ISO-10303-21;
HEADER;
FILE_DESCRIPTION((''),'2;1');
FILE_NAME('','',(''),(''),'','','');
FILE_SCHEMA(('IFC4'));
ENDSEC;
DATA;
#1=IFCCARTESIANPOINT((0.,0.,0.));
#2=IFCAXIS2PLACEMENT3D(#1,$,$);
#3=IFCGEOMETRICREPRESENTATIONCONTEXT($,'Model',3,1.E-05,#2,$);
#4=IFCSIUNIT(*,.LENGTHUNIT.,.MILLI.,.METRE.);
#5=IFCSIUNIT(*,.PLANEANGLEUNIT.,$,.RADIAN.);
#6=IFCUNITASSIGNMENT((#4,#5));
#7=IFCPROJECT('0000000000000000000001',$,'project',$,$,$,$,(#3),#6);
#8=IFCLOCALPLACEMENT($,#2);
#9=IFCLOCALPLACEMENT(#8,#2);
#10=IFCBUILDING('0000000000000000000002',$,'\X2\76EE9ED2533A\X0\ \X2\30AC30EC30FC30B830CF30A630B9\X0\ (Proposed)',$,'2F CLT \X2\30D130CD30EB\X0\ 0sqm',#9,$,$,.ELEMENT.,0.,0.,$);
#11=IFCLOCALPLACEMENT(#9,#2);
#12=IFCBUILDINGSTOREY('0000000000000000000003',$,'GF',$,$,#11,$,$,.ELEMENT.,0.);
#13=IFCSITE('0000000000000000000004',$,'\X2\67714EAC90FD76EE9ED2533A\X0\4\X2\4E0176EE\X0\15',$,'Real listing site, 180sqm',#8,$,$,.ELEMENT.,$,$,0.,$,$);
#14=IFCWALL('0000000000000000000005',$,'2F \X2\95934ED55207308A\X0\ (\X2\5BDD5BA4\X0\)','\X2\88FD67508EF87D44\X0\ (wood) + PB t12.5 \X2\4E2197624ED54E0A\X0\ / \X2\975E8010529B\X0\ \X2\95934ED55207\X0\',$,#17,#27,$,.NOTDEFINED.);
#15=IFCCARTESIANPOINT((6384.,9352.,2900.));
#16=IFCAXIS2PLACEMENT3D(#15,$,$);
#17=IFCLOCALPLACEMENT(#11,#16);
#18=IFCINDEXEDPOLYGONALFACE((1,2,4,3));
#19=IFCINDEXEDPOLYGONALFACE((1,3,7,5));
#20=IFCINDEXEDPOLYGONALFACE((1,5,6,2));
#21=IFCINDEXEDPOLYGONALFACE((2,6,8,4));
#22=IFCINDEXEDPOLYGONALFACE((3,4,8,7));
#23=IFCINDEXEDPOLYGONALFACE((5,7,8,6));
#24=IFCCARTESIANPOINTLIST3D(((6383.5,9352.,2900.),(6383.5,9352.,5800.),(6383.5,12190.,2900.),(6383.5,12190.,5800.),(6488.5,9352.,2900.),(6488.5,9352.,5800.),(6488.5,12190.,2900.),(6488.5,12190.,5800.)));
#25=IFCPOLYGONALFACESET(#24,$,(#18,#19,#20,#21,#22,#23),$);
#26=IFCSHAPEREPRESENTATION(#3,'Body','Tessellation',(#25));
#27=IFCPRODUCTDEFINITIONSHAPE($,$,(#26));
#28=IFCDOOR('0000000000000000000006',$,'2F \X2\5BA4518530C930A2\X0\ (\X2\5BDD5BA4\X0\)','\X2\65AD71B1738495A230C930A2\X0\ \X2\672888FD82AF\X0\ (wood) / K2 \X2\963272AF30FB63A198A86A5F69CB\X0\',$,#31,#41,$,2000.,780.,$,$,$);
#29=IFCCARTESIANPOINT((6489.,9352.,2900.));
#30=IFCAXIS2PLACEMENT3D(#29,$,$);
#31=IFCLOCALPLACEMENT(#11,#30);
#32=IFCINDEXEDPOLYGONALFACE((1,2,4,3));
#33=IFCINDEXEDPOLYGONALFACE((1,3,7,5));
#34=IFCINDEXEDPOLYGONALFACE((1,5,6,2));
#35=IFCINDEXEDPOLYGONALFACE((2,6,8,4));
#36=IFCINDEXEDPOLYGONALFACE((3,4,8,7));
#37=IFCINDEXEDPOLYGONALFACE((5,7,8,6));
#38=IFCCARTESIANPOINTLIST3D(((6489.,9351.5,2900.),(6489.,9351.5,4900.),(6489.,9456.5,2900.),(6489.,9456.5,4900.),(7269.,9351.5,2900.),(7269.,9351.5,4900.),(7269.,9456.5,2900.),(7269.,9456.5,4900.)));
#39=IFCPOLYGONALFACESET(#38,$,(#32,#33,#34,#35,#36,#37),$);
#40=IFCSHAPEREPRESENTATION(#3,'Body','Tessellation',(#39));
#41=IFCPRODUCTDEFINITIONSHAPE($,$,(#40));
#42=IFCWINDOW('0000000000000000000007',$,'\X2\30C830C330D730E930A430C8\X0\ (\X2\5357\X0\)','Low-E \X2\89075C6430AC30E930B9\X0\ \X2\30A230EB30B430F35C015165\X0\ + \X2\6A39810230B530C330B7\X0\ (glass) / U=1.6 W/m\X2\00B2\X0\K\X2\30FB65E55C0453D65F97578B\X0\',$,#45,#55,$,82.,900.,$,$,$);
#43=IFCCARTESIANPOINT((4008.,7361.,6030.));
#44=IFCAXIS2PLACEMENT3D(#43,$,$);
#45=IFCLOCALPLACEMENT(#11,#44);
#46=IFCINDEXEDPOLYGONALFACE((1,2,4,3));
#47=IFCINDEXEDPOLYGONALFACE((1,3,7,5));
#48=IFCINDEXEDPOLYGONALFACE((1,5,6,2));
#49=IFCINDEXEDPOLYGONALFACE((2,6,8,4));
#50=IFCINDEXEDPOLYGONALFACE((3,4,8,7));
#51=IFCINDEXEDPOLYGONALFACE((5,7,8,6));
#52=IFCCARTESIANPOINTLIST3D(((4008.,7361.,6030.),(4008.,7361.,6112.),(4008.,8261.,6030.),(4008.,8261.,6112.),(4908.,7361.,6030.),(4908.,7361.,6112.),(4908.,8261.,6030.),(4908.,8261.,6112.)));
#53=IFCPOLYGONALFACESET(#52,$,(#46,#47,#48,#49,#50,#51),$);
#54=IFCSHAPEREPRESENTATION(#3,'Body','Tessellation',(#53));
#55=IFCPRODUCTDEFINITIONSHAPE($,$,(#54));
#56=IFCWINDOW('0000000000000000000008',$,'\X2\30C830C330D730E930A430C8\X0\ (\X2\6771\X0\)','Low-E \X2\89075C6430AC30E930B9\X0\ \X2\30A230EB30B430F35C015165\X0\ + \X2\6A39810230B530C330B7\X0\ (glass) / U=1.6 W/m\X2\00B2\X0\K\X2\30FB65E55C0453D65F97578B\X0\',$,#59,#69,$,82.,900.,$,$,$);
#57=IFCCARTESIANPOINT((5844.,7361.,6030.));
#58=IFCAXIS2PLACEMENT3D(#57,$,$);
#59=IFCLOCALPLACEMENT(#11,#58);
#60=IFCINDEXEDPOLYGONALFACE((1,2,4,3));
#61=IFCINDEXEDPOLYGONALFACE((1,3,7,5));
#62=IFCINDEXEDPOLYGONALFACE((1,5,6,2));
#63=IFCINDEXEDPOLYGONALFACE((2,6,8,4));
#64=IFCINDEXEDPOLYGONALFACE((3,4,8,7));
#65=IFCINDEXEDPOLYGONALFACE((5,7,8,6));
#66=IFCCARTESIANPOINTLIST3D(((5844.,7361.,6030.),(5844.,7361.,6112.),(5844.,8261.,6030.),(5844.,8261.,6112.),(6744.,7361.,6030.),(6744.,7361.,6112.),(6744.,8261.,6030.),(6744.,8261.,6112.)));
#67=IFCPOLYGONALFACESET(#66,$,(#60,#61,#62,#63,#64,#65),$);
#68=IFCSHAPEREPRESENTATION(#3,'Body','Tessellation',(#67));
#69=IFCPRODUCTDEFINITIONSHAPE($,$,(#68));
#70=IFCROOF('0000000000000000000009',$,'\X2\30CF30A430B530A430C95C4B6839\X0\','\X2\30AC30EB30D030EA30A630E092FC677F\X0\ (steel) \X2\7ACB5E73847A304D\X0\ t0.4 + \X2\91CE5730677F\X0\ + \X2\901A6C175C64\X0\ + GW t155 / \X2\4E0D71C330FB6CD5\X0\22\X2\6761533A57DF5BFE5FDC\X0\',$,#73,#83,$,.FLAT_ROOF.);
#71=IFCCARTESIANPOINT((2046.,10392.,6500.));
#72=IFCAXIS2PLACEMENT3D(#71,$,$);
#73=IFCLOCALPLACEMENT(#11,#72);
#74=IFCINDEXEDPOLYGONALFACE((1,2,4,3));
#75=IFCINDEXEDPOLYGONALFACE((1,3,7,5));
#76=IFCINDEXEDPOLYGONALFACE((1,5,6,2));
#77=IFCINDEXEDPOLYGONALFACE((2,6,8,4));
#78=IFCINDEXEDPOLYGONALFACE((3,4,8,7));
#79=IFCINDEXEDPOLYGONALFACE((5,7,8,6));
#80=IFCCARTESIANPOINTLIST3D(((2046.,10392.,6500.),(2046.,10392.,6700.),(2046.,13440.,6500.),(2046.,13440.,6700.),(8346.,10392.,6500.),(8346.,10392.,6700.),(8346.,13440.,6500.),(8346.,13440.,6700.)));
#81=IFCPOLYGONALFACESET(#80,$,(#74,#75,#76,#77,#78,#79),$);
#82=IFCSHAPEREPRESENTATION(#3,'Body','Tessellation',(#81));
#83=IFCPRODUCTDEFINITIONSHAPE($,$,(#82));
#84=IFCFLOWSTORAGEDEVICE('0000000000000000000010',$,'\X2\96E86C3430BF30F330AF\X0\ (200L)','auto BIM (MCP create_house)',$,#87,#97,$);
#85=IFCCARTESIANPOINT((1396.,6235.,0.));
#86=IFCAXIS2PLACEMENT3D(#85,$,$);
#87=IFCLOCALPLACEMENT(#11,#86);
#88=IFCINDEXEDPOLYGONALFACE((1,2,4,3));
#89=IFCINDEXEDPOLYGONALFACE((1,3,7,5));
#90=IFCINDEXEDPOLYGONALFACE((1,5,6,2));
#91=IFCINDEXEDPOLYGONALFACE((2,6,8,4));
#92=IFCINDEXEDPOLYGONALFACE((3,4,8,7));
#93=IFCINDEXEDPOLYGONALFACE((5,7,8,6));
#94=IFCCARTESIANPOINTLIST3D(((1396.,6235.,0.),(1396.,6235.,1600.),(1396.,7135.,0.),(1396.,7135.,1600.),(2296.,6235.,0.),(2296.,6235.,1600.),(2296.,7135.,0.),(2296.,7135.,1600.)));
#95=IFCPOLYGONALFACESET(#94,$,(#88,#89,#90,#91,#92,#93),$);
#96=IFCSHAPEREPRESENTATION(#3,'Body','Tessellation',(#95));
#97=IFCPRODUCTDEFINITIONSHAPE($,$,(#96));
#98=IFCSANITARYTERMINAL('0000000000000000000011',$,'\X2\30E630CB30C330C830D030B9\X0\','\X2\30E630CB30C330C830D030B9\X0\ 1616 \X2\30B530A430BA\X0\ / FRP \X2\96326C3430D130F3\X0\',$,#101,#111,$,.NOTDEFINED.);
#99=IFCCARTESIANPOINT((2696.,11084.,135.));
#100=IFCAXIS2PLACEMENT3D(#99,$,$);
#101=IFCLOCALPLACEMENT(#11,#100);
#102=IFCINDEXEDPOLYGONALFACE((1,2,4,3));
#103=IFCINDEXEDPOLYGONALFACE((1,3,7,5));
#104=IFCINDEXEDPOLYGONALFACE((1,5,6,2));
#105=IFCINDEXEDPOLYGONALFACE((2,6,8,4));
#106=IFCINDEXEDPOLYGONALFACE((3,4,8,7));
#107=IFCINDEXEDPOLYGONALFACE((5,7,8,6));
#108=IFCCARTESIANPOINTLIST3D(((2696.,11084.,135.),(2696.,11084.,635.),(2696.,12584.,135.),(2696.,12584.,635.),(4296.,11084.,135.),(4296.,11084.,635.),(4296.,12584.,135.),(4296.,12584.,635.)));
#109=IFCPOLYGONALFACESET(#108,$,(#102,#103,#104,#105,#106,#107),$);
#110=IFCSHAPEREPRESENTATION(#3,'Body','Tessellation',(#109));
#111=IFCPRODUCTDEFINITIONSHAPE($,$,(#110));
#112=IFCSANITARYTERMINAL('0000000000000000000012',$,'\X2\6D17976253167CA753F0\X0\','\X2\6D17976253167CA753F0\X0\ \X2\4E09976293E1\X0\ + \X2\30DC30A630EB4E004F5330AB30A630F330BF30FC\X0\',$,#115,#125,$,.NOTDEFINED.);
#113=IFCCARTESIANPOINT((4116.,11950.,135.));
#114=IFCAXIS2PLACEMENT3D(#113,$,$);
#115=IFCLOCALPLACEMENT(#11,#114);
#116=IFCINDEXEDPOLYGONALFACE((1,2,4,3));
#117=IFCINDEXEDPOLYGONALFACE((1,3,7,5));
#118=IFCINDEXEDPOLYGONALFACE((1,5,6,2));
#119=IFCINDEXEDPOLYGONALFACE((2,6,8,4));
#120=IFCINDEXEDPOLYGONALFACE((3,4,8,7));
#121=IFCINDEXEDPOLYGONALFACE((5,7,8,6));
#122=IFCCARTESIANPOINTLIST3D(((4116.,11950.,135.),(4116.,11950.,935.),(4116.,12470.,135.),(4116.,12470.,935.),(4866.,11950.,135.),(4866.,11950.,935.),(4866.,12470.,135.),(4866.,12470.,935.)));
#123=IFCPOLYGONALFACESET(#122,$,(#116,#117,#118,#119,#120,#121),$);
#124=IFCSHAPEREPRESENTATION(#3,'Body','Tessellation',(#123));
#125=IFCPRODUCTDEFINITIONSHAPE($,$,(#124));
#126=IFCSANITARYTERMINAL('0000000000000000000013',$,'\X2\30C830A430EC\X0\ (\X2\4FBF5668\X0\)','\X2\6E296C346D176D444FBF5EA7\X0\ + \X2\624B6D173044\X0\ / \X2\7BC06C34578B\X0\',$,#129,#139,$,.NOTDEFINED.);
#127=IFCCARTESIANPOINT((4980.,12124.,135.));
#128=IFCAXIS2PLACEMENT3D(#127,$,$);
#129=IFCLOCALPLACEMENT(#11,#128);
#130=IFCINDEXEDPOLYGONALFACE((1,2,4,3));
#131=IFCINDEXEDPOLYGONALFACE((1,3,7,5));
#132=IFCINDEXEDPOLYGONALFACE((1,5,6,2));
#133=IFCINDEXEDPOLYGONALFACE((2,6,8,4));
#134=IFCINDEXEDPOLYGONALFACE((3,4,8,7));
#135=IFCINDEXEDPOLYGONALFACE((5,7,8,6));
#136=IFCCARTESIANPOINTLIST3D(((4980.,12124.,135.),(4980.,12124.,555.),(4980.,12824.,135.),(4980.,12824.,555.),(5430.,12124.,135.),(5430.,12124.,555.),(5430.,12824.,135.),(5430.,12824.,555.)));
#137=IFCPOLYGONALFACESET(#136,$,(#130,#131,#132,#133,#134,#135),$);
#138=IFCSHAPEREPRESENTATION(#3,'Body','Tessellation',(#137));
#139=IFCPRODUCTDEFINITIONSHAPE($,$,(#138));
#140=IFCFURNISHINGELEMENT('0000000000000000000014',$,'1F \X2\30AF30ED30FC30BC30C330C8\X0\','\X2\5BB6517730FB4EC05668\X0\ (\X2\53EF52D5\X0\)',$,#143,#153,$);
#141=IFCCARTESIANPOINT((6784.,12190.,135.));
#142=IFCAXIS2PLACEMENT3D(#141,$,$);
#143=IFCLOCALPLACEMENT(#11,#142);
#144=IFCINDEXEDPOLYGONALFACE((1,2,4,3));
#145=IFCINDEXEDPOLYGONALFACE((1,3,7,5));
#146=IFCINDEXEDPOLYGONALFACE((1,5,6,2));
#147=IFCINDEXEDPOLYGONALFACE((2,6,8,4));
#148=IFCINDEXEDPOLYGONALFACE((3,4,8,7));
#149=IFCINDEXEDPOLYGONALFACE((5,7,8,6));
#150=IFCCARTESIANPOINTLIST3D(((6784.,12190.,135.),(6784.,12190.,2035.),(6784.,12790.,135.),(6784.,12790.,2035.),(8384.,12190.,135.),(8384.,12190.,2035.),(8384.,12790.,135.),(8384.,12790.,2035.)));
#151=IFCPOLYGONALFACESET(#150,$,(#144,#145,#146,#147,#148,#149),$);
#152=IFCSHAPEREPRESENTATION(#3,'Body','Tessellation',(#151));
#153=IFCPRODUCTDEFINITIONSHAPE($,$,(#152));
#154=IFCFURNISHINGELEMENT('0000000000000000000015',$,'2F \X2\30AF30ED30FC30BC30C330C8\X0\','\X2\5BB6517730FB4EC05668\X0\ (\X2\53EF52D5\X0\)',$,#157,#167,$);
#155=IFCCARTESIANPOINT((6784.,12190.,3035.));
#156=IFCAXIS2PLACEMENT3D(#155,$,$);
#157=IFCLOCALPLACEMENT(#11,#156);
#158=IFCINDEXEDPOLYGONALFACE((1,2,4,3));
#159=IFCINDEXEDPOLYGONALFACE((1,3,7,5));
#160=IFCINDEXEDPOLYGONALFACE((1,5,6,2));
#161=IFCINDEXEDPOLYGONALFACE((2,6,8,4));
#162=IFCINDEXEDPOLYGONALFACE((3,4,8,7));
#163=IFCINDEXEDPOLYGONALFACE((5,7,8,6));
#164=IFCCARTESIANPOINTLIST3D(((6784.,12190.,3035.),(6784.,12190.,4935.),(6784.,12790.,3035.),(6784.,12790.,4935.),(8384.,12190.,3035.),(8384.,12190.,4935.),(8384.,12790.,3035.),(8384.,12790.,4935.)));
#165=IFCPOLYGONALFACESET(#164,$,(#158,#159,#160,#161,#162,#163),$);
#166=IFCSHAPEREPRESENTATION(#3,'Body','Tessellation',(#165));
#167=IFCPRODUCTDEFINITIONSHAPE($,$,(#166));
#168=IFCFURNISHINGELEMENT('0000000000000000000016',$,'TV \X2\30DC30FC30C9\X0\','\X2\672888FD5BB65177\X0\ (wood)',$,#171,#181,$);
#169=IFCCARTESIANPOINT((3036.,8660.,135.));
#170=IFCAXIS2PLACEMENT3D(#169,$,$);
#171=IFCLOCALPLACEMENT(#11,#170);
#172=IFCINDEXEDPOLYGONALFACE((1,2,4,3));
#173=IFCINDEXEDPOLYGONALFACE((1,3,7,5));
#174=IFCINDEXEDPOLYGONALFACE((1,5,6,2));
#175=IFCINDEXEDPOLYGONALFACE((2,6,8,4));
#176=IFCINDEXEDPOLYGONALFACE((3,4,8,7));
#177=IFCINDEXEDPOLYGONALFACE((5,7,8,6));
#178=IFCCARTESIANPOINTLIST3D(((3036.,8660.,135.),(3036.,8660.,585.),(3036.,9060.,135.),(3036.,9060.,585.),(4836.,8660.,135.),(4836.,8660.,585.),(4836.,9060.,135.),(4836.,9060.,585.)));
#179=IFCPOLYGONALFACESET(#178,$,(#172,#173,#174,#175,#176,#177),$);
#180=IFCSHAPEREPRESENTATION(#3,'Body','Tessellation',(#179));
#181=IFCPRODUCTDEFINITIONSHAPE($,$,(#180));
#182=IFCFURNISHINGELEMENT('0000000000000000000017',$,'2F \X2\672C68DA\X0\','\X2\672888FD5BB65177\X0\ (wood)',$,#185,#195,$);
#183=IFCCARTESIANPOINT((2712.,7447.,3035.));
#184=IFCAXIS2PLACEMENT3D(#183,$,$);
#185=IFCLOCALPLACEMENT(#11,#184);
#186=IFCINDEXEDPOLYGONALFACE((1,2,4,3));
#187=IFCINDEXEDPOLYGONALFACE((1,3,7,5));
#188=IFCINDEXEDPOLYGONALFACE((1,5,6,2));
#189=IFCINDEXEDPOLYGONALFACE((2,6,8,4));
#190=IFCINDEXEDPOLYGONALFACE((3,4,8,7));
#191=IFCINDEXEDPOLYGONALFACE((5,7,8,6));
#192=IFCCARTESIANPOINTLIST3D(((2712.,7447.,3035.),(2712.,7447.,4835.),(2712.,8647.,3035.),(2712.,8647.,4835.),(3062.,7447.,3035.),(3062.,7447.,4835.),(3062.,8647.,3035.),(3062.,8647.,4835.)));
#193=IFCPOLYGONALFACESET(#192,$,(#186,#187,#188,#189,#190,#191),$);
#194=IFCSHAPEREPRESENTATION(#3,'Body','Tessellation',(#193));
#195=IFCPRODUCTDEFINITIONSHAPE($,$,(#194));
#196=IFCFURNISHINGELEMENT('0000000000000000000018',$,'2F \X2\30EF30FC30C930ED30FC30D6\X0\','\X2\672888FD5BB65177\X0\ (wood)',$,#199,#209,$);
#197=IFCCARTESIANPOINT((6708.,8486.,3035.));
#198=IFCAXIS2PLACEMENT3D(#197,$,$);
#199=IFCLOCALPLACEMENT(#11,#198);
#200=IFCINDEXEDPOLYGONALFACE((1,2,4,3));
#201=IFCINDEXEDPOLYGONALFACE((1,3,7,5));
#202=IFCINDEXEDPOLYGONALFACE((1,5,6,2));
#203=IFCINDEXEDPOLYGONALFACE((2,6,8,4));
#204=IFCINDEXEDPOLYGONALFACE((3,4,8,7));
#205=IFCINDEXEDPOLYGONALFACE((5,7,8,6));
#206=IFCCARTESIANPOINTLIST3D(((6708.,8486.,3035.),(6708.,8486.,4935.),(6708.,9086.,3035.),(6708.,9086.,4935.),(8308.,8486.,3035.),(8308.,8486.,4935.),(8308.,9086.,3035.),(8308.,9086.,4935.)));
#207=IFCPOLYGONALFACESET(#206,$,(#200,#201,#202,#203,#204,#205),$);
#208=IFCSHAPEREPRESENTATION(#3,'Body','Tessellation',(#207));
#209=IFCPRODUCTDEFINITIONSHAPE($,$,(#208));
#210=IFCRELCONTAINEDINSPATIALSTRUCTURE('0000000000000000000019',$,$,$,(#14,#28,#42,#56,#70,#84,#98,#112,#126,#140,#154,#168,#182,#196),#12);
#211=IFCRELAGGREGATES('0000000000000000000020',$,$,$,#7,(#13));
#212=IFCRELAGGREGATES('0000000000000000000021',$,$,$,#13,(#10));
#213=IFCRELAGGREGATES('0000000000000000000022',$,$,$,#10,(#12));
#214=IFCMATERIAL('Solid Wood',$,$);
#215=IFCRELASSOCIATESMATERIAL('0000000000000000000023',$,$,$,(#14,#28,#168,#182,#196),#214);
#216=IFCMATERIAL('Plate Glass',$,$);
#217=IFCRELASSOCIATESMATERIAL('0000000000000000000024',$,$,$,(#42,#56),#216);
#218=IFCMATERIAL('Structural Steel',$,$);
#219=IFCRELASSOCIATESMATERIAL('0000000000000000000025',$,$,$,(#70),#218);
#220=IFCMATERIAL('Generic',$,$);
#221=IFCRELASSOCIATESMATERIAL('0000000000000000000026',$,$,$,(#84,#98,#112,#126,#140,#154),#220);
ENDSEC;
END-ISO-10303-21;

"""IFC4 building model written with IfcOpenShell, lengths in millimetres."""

from ifc_helpers import new_model, si_unit, frame, frame_2d, origin, place, context, project, spatial, rectangle, extrude, material, element, save


model = new_model("IFC4")

# Units and contexts
model_context = context("Model", 3, precision=1e-05, world=origin())
ifc_project = project(units=[si_unit("LENGTHUNIT", "METRE", prefix="MILLI"), si_unit("PLANEANGLEUNIT", "RADIAN")], contexts=[model_context])

# Site, building, storey
site_placement = place(None, origin())
site = spatial("IfcSite", under=ifc_project, at=site_placement, Name="東京都目黒区4丁目15", ObjectType="Real listing site, 180sqm", CompositionType="ELEMENT", RefElevation=0.0)
building_placement = place(site_placement, origin())
building = spatial("IfcBuilding", under=site, at=building_placement, Name="目黒区 ガレージハウス (Proposed)", ObjectType="2F CLT パネル 0sqm", CompositionType="ELEMENT", ElevationOfRefHeight=0.0, ElevationOfTerrain=0.0)
storey_placement = place(building_placement, origin())
storey = spatial("IfcBuildingStorey", under=building, at=storey_placement, Name="GF", CompositionType="ELEMENT", Elevation=0.0)

# Shared definitions
ifc_material_1 = material(Name="Solid Wood")
ifc_material_2 = material(Name="Plate Glass")

# Wall
wall_1_placement = place(storey_placement, frame((6384.0, 9352.0, 2900.0)))
element("IfcWall", 1, at=wall_1_placement, inside=storey, material=ifc_material_1, Name="2F 間仕切り (寝室)", Description="製材軸組 (wood) + PB t12.5 両面仕上 / 非耐力 間仕切", PredefinedType="NOTDEFINED", context=model_context, shape_type="SweptSolid", body=[
    extrude(rectangle(XDim=105.0, YDim=2838.0, at=frame_2d((52.0, 1419.0))), frame((6384.0, 9352.0, 2900.0)), (0.0, 0.0, 1.0), 2900.0),
])

# Door
door_1_placement = place(storey_placement, frame((6489.0, 9352.0, 2900.0)))
element("IfcDoor", 2, at=door_1_placement, inside=storey, material=ifc_material_1, Name="2F 室内ドア (寝室)", Description="断熱玄関ドア 木製芯 (wood) / K2 防犯・採風機構", OverallHeight=2000.0, OverallWidth=780.0, context=model_context, shape_type="SweptSolid", body=[
    extrude(rectangle(XDim=780.0, YDim=105.0, at=frame_2d((390.0, 52.0))), frame((6489.0, 9352.0, 2900.0)), (0.0, 0.0, 1.0), 2000.0),
])

# Windows
window_1_placement = place(storey_placement, frame((4008.0, 7361.0, 6030.0)))
element("IfcWindow", 3, at=window_1_placement, inside=storey, material=ifc_material_2, Name="トップライト (南)", Description="Low-E 複層ガラス アルゴン封入 + 樹脂サッシ (glass) / U=1.6 W/m²K・日射取得型", OverallHeight=82.0, OverallWidth=900.0, context=model_context, shape_type="SweptSolid", body=[
    extrude(rectangle(XDim=900.0, YDim=900.0, at=frame_2d((450.0, 450.0))), frame((4008.0, 7361.0, 6030.0)), (0.0, 0.0, 1.0), 82.0),
])
window_2_placement = place(storey_placement, frame((5844.0, 7361.0, 6030.0)))
element("IfcWindow", 4, at=window_2_placement, inside=storey, material=ifc_material_2, Name="トップライト (東)", Description="Low-E 複層ガラス アルゴン封入 + 樹脂サッシ (glass) / U=1.6 W/m²K・日射取得型", OverallHeight=82.0, OverallWidth=900.0, context=model_context, shape_type="SweptSolid", body=[
    extrude(rectangle(XDim=900.0, YDim=900.0, at=frame_2d((450.0, 450.0))), frame((5844.0, 7361.0, 6030.0)), (0.0, 0.0, 1.0), 82.0),
])

# Roof
ifc_material_3 = material(Name="Structural Steel")
roof_placement = place(storey_placement, frame((2046.0, 10392.0, 6500.0)))
element("IfcRoof", 5, at=roof_placement, inside=storey, material=ifc_material_3, Name="ハイサイド屋根", Description="ガルバリウム鋼板 (steel) 立平葺き t0.4 + 野地板 + 通気層 + GW t155 / 不燃・法22条区域対応", PredefinedType="FLAT_ROOF", context=model_context, shape_type="SweptSolid", body=[
    extrude(rectangle(XDim=6300.0, YDim=3048.0, at=frame_2d((3150.0, 1524.0))), frame((2046.0, 10392.0, 6500.0)), (0.0, 0.0, 1.0), 200.0),
])

# Flow storage device
ifc_material_4 = material(Name="Generic")
flow_storage_device_placement = place(storey_placement, frame((1396.0, 6235.0, 0.0)))
element("IfcFlowStorageDevice", 6, at=flow_storage_device_placement, inside=storey, material=ifc_material_4, Name="雨水タンク (200L)", Description="auto BIM (MCP create_house)", context=model_context, shape_type="SweptSolid", body=[
    extrude(rectangle(XDim=900.0, YDim=900.0, at=frame_2d((450.0, 450.0))), frame((1396.0, 6235.0, 0.0)), (0.0, 0.0, 1.0), 1600.0),
])

# Sanitary terminals
sanitary_terminal_1_placement = place(storey_placement, frame((2696.0, 11084.0, 135.0)))
element("IfcSanitaryTerminal", 7, at=sanitary_terminal_1_placement, inside=storey, material=ifc_material_4, Name="ユニットバス", Description="ユニットバス 1616 サイズ / FRP 防水パン", PredefinedType="NOTDEFINED", context=model_context, shape_type="SweptSolid", body=[
    extrude(rectangle(XDim=1600.0, YDim=1500.0, at=frame_2d((800.0, 750.0))), frame((2696.0, 11084.0, 135.0)), (0.0, 0.0, 1.0), 500.0),
])
sanitary_terminal_2_placement = place(storey_placement, frame((4116.0, 11950.0, 135.0)))
element("IfcSanitaryTerminal", 8, at=sanitary_terminal_2_placement, inside=storey, material=ifc_material_4, Name="洗面化粧台", Description="洗面化粧台 三面鏡 + ボウル一体カウンター", PredefinedType="NOTDEFINED", context=model_context, shape_type="SweptSolid", body=[
    extrude(rectangle(XDim=750.0, YDim=520.0, at=frame_2d((375.0, 260.0))), frame((4116.0, 11950.0, 135.0)), (0.0, 0.0, 1.0), 800.0),
])
sanitary_terminal_3_placement = place(storey_placement, frame((4980.0, 12124.0, 135.0)))
element("IfcSanitaryTerminal", 9, at=sanitary_terminal_3_placement, inside=storey, material=ifc_material_4, Name="トイレ (便器)", Description="温水洗浄便座 + 手洗い / 節水型", PredefinedType="NOTDEFINED", context=model_context, shape_type="SweptSolid", body=[
    extrude(rectangle(XDim=450.0, YDim=700.0, at=frame_2d((225.0, 350.0))), frame((4980.0, 12124.0, 135.0)), (0.0, 0.0, 1.0), 420.0),
])

# Furnishing elements
furnishing_1_placement = place(storey_placement, frame((6784.0, 12190.0, 135.0)))
element("IfcFurnishingElement", 10, at=furnishing_1_placement, inside=storey, material=ifc_material_4, Name="1F クローゼット", Description="家具・什器 (可動)", context=model_context, shape_type="SweptSolid", body=[
    extrude(rectangle(XDim=1600.0, YDim=600.0, at=frame_2d((800.0, 300.0))), frame((6784.0, 12190.0, 135.0)), (0.0, 0.0, 1.0), 1900.0),
])
furnishing_2_placement = place(storey_placement, frame((6784.0, 12190.0, 3035.0)))
element("IfcFurnishingElement", 11, at=furnishing_2_placement, inside=storey, material=ifc_material_4, Name="2F クローゼット", Description="家具・什器 (可動)", context=model_context, shape_type="SweptSolid", body=[
    extrude(rectangle(XDim=1600.0, YDim=600.0, at=frame_2d((800.0, 300.0))), frame((6784.0, 12190.0, 3035.0)), (0.0, 0.0, 1.0), 1900.0),
])
furnishing_3_placement = place(storey_placement, frame((3036.0, 8660.0, 135.0)))
element("IfcFurnishingElement", 12, at=furnishing_3_placement, inside=storey, material=ifc_material_1, Name="TV ボード", Description="木製家具 (wood)", context=model_context, shape_type="SweptSolid", body=[
    extrude(rectangle(XDim=1800.0, YDim=400.0, at=frame_2d((900.0, 200.0))), frame((3036.0, 8660.0, 135.0)), (0.0, 0.0, 1.0), 450.0),
])
furnishing_4_placement = place(storey_placement, frame((2712.0, 7447.0, 3035.0)))
element("IfcFurnishingElement", 13, at=furnishing_4_placement, inside=storey, material=ifc_material_1, Name="2F 本棚", Description="木製家具 (wood)", context=model_context, shape_type="SweptSolid", body=[
    extrude(rectangle(XDim=350.0, YDim=1200.0, at=frame_2d((175.0, 600.0))), frame((2712.0, 7447.0, 3035.0)), (0.0, 0.0, 1.0), 1800.0),
])
furnishing_5_placement = place(storey_placement, frame((6708.0, 8486.0, 3035.0)))
element("IfcFurnishingElement", 14, at=furnishing_5_placement, inside=storey, material=ifc_material_1, Name="2F ワードローブ", Description="木製家具 (wood)", context=model_context, shape_type="SweptSolid", body=[
    extrude(rectangle(XDim=1600.0, YDim=600.0, at=frame_2d((800.0, 300.0))), frame((6708.0, 8486.0, 3035.0)), (0.0, 0.0, 1.0), 1900.0),
])

save(model, "model.ifc")
